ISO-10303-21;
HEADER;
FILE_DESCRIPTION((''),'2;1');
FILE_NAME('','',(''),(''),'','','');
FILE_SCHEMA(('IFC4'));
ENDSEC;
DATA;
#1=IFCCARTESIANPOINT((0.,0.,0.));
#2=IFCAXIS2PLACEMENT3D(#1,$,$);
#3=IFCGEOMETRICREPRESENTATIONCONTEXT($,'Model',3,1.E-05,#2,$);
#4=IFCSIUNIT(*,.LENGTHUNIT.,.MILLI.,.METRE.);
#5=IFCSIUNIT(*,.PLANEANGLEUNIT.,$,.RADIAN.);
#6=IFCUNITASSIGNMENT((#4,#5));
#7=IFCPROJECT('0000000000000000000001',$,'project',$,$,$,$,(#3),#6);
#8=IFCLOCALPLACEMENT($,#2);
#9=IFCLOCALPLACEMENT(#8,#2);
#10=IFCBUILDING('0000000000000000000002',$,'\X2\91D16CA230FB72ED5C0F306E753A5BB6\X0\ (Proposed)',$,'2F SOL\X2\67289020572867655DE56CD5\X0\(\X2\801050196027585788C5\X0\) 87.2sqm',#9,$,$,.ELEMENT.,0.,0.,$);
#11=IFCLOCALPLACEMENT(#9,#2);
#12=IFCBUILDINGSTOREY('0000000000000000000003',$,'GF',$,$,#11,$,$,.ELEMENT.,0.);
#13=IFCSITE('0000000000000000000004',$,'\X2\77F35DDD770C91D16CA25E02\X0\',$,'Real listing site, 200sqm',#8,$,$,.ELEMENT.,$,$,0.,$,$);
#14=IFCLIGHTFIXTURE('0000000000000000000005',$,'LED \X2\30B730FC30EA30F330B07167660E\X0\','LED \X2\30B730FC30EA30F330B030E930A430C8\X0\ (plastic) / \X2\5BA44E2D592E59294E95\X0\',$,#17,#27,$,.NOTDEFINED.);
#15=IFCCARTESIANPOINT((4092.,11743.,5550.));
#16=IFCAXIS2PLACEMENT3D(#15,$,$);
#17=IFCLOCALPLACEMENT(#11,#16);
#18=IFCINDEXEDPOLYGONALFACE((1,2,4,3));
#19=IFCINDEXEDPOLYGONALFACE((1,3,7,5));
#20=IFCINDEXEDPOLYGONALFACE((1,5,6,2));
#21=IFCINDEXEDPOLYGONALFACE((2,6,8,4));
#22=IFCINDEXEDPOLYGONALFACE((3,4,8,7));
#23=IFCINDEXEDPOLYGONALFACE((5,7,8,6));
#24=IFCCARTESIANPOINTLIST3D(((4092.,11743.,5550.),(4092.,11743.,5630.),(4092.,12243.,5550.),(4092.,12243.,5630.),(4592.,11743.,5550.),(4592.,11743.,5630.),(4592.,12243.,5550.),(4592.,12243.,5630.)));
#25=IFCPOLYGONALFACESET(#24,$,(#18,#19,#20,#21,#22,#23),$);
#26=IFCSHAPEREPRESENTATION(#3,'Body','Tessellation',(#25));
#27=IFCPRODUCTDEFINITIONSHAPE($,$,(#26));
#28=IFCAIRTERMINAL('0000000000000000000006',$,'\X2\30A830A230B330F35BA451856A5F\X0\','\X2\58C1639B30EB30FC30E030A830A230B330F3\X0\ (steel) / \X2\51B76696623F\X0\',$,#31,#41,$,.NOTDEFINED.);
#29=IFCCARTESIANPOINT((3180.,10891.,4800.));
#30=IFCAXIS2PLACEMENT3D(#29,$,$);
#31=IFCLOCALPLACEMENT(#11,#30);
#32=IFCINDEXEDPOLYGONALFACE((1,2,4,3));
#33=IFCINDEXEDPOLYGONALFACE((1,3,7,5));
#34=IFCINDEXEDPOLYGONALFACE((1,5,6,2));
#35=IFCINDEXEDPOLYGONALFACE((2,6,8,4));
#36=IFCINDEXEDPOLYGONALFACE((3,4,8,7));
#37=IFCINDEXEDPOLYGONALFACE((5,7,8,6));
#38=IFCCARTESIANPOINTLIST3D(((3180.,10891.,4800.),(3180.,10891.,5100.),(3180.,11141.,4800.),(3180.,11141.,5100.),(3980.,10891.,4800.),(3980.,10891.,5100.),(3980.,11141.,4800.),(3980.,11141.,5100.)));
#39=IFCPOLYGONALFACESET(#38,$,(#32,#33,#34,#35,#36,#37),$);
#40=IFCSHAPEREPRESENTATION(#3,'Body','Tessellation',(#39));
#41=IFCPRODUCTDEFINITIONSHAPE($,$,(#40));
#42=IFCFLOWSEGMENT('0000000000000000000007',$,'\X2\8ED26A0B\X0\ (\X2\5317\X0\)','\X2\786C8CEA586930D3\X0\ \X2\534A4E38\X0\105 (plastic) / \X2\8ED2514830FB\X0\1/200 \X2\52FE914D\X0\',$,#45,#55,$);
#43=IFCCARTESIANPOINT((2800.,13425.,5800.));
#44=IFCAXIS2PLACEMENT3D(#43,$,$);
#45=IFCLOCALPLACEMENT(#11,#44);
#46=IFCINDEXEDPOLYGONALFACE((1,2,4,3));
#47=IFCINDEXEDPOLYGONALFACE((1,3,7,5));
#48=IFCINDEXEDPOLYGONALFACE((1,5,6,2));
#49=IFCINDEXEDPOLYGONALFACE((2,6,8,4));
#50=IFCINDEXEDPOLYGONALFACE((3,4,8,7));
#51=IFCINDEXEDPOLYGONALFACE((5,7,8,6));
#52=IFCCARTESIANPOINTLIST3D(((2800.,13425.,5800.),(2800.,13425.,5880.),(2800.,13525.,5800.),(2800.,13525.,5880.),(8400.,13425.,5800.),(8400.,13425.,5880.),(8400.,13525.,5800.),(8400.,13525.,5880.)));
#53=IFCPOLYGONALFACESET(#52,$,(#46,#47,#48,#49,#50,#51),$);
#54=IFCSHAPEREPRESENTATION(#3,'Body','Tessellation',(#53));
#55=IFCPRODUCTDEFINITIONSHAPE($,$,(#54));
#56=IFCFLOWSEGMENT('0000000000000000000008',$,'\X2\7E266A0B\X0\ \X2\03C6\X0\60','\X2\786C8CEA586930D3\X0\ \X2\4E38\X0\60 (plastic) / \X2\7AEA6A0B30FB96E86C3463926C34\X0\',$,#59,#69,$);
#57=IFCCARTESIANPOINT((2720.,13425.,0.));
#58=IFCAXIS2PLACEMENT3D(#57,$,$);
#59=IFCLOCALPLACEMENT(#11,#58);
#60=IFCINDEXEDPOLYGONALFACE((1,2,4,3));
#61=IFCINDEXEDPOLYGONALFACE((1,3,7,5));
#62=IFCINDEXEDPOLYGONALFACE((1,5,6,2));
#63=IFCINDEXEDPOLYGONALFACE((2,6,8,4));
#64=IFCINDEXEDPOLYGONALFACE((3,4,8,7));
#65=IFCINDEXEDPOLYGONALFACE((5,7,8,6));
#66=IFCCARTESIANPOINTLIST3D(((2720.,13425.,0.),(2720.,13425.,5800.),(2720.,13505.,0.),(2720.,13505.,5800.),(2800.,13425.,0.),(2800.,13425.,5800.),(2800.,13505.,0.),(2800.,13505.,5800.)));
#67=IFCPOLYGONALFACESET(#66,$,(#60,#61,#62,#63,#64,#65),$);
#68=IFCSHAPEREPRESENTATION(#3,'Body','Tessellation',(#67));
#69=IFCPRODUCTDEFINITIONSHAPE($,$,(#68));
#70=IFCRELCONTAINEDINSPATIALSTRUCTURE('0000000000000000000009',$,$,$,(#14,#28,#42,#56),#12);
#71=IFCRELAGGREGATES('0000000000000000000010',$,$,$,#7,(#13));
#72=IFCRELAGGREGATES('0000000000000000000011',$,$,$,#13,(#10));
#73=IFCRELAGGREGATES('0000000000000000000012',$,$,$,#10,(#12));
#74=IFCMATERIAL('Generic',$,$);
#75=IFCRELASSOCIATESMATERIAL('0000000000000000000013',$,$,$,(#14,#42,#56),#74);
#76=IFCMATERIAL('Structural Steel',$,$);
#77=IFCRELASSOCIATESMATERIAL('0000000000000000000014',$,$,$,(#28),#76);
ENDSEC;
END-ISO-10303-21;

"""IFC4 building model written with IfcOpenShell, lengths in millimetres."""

from ifc_helpers import new_model, si_unit, frame, frame_2d, origin, place, context, project, spatial, rectangle, extrude, material, element, save


model = new_model("IFC4")

# Units and contexts
model_context = context("Model", 3, precision=1e-05, world=origin())
ifc_project = project(units=[si_unit("LENGTHUNIT", "METRE", prefix="MILLI"), si_unit("PLANEANGLEUNIT", "RADIAN")], contexts=[model_context])

# Site, building, storey
site_placement = place(None, origin())
site = spatial("IfcSite", under=ifc_project, at=site_placement, Name="石川県金沢市", ObjectType="Real listing site, 200sqm", CompositionType="ELEMENT", RefElevation=0.0)
building_placement = place(site_placement, origin())
building = spatial("IfcBuilding", under=site, at=building_placement, Name="金沢・狭小の町家 (Proposed)", ObjectType="2F SOL木造在来工法(耐候性塗装) 87.2sqm", CompositionType="ELEMENT", ElevationOfRefHeight=0.0, ElevationOfTerrain=0.0)
storey_placement = place(building_placement, origin())
storey = spatial("IfcBuildingStorey", under=building, at=storey_placement, Name="GF", CompositionType="ELEMENT", Elevation=0.0)

# Shared definitions
ifc_material_1 = material(Name="Generic")

# Shared definitions
ifc_material_2 = material(Name="Structural Steel")

# Light fixture
light_fixture_placement = place(storey_placement, frame((4092.0, 11743.0, 5550.0)))
element("IfcLightFixture", 1, at=light_fixture_placement, inside=storey, material=ifc_material_1, Name="LED シーリング照明", Description="LED シーリングライト (plastic) / 室中央天井", PredefinedType="NOTDEFINED", context=model_context, shape_type="SweptSolid", body=[
    extrude(rectangle(XDim=500.0, YDim=500.0, at=frame_2d((250.0, 250.0))), frame((4092.0, 11743.0, 5550.0)), (0.0, 0.0, 1.0), 80.0),
])

# Air terminal
air_terminal_1_placement = place(storey_placement, frame((3180.0, 10891.0, 4800.0)))
element("IfcAirTerminal", 2, at=air_terminal_1_placement, inside=storey, material=ifc_material_2, Name="エアコン室内機", Description="壁掛ルームエアコン (steel) / 冷暖房", PredefinedType="NOTDEFINED", context=model_context, shape_type="SweptSolid", body=[
    extrude(rectangle(XDim=800.0, YDim=250.0, at=frame_2d((400.0, 125.0))), frame((3180.0, 10891.0, 4800.0)), (0.0, 0.0, 1.0), 300.0),
])

# Flow segments
flow_segment_1_placement = place(storey_placement, frame((2800.0, 13425.0, 5800.0)))
element("IfcFlowSegment", 3, at=flow_segment_1_placement, inside=storey, material=ifc_material_1, Name="軒樋 (北)", Description="硬質塩ビ 半丸105 (plastic) / 軒先・1/200 勾配", context=model_context, shape_type="SweptSolid", body=[
    extrude(rectangle(XDim=5600.0, YDim=100.0, at=frame_2d((2800.0, 50.0))), frame((2800.0, 13425.0, 5800.0)), (0.0, 0.0, 1.0), 80.0),
])
flow_segment_2_placement = place(storey_placement, frame((2720.0, 13425.0, 0.0)))
element("IfcFlowSegment", 4, at=flow_segment_2_placement, inside=storey, material=ifc_material_1, Name="縦樋 φ60", Description="硬質塩ビ 丸60 (plastic) / 竪樋・雨水排水", context=model_context, shape_type="SweptSolid", body=[
    extrude(rectangle(XDim=80.0, YDim=80.0, at=frame_2d((40.0, 40.0))), frame((2720.0, 13425.0, 0.0)), (0.0, 0.0, 1.0), 5800.0),
])

save(model, "model.ifc")
